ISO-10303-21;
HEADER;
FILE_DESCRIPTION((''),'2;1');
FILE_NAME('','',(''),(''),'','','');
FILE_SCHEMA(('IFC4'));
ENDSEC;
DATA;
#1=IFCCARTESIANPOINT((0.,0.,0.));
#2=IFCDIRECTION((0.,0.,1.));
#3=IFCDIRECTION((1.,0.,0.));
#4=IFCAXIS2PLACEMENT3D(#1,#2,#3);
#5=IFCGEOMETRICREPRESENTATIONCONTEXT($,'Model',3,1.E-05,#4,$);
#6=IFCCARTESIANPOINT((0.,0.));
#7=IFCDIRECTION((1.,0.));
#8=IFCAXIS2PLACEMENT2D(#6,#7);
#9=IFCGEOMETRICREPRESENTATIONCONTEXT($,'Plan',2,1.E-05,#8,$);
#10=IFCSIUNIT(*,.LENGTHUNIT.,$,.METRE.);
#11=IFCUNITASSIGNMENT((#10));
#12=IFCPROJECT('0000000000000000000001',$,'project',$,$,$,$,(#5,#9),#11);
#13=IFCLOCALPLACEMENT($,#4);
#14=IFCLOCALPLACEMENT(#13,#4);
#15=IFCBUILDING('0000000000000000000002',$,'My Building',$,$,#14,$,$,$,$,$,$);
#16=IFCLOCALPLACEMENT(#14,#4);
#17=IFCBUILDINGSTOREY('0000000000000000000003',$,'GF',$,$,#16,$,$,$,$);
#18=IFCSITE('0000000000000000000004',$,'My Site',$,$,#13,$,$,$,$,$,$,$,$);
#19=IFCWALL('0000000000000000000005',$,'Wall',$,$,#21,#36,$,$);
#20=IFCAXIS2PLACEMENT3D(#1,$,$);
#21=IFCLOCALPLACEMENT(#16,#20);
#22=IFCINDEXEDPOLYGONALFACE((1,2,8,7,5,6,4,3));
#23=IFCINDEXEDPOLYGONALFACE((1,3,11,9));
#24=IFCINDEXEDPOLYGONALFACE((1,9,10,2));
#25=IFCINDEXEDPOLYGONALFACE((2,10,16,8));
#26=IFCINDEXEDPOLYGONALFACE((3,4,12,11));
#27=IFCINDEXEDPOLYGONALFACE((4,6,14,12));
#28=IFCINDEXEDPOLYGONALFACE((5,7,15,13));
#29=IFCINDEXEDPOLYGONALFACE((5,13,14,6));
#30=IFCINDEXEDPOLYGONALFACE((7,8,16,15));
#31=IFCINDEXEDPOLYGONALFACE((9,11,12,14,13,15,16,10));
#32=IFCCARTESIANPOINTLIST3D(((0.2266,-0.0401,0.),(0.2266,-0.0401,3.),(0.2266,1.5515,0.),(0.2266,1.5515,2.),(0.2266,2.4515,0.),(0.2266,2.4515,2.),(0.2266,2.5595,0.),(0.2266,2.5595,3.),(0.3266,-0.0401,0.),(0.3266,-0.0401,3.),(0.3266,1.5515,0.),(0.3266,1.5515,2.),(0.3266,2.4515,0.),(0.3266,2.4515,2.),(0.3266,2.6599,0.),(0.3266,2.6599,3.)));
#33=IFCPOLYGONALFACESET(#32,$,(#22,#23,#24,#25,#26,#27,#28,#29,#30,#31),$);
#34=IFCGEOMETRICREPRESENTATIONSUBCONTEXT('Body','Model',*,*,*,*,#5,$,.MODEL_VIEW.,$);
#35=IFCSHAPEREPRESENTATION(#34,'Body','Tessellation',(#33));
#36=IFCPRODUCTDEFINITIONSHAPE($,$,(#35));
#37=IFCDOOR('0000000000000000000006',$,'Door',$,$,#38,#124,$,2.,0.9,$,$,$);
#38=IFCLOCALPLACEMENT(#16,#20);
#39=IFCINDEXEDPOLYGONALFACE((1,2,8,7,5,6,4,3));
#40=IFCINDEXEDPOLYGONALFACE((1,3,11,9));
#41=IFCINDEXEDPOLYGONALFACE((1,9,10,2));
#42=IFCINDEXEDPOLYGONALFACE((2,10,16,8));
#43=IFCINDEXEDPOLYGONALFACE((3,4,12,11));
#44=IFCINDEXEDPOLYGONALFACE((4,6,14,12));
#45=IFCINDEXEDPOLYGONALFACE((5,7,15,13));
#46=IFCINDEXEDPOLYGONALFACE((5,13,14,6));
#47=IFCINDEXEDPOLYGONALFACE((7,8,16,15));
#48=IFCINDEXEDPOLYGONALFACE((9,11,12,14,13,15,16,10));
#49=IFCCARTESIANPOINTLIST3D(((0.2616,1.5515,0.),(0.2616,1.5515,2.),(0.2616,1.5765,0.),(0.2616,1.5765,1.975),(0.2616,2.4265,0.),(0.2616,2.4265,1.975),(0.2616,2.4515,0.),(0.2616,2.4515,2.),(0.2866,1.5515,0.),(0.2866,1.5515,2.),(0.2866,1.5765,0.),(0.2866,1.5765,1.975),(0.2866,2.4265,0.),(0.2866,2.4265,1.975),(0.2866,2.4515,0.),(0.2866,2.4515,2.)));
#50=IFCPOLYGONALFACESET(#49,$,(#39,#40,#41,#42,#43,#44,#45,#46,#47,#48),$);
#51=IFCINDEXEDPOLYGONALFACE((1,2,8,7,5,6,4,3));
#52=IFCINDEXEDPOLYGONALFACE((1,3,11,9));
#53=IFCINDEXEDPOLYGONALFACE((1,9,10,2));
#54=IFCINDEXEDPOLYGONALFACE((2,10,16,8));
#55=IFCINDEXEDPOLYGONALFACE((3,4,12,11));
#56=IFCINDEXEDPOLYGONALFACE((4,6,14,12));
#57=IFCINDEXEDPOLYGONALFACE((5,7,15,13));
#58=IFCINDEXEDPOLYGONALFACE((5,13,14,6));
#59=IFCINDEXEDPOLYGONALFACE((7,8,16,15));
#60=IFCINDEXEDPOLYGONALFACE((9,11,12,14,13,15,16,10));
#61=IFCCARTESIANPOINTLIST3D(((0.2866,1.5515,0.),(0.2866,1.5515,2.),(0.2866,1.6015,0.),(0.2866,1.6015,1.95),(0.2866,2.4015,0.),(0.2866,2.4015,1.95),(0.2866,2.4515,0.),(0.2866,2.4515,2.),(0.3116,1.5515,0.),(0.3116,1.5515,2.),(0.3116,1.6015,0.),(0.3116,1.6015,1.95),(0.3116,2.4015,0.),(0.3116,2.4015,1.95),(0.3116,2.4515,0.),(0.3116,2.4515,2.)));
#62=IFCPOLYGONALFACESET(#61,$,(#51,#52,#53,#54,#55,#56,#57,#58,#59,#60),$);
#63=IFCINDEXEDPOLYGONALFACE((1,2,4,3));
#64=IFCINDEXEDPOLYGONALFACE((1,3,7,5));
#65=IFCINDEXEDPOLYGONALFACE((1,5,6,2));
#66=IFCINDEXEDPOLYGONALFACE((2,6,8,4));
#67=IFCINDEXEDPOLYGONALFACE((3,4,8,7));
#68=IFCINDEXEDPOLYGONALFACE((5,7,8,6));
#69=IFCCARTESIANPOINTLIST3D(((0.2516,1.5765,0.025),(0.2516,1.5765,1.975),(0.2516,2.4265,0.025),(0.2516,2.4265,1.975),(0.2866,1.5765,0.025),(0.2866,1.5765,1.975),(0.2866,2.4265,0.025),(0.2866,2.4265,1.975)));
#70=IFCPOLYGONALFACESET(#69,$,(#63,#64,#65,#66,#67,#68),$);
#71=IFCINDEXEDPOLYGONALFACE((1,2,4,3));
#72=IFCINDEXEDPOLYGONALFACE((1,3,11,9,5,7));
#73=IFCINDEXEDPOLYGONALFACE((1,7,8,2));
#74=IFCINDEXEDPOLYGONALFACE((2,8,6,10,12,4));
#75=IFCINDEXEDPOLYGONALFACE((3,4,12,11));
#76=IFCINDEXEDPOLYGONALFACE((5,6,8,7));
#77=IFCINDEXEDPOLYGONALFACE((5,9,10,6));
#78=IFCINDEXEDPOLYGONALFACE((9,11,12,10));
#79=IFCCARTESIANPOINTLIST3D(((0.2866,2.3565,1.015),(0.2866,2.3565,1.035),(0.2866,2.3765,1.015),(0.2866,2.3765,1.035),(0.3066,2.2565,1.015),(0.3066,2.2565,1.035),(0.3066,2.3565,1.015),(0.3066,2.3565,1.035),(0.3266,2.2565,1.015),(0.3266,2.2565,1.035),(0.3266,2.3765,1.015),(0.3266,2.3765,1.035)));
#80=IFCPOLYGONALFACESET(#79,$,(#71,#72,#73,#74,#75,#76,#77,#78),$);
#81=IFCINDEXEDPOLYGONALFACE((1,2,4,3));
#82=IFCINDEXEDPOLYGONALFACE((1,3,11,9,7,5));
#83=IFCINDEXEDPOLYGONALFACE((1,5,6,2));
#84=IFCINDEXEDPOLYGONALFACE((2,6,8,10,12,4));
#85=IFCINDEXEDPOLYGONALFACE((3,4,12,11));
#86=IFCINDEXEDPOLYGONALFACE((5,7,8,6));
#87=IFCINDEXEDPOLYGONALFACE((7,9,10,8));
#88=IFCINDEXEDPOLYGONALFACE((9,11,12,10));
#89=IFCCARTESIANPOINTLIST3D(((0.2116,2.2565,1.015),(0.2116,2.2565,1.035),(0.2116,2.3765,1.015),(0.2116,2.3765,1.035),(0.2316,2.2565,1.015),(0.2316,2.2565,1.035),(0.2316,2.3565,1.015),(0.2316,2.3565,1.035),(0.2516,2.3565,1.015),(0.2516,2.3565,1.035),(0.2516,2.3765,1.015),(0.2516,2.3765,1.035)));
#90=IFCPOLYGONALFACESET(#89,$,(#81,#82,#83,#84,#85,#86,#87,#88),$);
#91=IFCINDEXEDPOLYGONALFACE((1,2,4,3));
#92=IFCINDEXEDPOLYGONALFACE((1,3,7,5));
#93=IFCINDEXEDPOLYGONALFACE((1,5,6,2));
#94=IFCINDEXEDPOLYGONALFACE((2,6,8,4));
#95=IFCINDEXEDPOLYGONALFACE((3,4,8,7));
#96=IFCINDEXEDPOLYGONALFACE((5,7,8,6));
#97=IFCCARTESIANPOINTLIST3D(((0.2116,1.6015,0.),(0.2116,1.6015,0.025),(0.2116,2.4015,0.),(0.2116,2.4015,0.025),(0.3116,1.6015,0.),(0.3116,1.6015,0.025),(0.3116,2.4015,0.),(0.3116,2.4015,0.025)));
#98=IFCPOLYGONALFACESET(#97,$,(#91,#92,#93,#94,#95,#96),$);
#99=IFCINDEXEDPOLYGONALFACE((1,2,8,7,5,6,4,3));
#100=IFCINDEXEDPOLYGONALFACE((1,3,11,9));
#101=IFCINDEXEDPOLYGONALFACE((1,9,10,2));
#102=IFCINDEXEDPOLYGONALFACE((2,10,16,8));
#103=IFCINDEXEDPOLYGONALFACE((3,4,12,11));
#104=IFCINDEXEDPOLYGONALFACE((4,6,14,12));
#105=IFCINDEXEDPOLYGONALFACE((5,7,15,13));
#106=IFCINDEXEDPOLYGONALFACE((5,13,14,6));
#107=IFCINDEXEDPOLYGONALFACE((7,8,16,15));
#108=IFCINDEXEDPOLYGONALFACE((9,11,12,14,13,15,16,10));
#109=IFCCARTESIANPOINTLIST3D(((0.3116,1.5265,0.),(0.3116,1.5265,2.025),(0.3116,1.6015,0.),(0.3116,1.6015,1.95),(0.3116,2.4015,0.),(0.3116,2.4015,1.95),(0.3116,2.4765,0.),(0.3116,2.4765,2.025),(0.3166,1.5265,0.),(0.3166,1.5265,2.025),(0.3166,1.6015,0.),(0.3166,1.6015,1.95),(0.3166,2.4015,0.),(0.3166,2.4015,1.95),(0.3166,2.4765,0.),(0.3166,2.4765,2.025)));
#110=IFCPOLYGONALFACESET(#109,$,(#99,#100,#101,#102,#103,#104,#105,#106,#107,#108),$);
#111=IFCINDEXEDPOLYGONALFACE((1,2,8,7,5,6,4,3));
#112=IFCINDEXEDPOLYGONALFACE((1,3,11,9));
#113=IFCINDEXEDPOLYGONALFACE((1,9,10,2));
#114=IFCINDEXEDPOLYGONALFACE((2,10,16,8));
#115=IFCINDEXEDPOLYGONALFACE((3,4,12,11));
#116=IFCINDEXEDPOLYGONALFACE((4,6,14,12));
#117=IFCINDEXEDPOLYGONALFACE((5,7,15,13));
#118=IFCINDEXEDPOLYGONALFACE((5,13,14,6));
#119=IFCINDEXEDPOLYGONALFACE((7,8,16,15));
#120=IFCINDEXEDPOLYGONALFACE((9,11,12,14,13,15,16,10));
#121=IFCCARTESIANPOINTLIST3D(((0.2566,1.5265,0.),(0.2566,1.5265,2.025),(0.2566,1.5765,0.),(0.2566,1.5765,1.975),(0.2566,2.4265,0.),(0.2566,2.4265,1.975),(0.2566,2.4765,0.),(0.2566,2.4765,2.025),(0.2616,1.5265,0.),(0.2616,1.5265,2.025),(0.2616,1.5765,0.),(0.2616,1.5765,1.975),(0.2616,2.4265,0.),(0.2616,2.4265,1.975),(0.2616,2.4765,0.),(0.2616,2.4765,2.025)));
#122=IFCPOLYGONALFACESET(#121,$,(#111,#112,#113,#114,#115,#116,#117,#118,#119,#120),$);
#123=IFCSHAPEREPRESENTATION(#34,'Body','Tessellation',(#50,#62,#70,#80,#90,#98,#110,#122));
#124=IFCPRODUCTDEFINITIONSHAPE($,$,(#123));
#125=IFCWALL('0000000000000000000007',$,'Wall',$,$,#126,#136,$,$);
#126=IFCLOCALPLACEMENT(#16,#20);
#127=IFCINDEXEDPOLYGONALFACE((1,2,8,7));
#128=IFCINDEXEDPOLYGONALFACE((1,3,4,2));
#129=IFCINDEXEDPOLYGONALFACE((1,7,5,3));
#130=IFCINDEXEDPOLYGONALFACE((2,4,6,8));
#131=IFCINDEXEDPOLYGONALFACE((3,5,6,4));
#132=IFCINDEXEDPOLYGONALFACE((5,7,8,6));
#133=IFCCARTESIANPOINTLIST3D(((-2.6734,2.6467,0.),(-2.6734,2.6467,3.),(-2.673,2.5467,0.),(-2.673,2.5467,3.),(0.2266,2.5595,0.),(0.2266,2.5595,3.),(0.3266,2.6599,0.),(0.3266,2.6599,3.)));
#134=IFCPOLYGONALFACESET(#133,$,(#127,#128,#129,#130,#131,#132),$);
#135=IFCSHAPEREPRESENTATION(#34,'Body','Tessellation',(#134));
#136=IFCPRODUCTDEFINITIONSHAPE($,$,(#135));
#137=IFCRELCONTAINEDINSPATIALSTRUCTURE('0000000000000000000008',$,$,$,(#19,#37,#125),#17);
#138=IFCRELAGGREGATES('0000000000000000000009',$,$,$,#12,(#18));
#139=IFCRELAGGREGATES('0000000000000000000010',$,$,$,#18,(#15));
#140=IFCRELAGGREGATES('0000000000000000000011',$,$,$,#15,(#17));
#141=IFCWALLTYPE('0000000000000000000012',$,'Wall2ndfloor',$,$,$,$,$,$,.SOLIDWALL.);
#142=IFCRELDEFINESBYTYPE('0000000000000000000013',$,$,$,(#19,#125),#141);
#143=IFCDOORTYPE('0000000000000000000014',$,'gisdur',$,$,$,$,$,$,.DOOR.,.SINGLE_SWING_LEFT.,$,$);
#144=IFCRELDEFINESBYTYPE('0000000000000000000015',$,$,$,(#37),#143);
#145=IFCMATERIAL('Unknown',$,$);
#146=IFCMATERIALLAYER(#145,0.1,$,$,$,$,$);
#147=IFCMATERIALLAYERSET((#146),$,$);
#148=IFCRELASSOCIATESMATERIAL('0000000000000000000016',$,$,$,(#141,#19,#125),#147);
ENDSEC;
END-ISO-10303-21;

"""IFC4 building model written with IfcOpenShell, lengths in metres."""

from ifc_helpers import new_model, entity, si_unit, frame, origin_with_axes, origin_2d_with_axis, place, context, subcontext, project, spatial, line, indexed_curve, outline, extrude, shape, source, transform, mapped, material, layer, layer_set, layer_usage, type_object, type_shapes, element, fill, save


model = new_model("IFC4")

# Units and contexts
model_context = context("Model", 3, precision=1e-05, world=origin_with_axes())
plan_context = context("Plan", 2, precision=1e-05, world=origin_2d_with_axis())
body_context_1 = subcontext(model_context, "Body", "Model", "MODEL_VIEW")
body_context_2 = subcontext(plan_context, "Body", "Plan", "PLAN_VIEW")
ifc_project = project(units=[si_unit("LENGTHUNIT", "METRE")], contexts=[model_context, plan_context])

# Site, building, storey
site_placement = place(None, origin_with_axes())
site = spatial("IfcSite", under=ifc_project, at=site_placement, Name="My Site")
building_placement = place(site_placement, origin_with_axes())
building = spatial("IfcBuilding", under=site, at=building_placement, Name="My Building")
storey_placement = place(building_placement, origin_with_axes())
storey = spatial("IfcBuildingStorey", under=building, at=storey_placement, Name="GF")

# Shared definitions
ifc_material = material(Name="Unknown")

# Shared definitions
ifc_layer_1 = layer(ifc_material, 0.1)
ifc_layer_set_1 = layer_set([ifc_layer_1])
wall_type_1 = type_object("IfcWallType", Name="Wall2ndfloor", PredefinedType="SOLIDWALL", material=ifc_layer_set_1)

# Wall, opening, door
ifc_layer_usage_1 = layer_usage(ifc_layer_set_1, "AXIS2", "POSITIVE", 0.0)
wall_1_placement = place(storey_placement, frame((0.3266, -0.0401, 0.0), z_axis=(0.0, 0.0, 1.0), x_axis=(0.0, 1.0, 0.0)))
wall_1 = element("IfcWall", 1, at=wall_1_placement, inside=storey, type_object=wall_type_1, material=ifc_layer_usage_1, Name="Wall", context=body_context_1, shape_type="SweptSolid", body=[
    extrude(outline(indexed_curve([(0.0, 0.0), (0.0, 0.1), (2.5996, 0.1), (2.7, 0.0)], segments=[line(1, 2, 3, 4, 1)])), origin_with_axes(), (0.0, 0.0, 1.0), 3.0),
])
shared_shape_1 = source(origin_with_axes(), body_context_1, "Body", "SweptSolid", [
    extrude(outline(indexed_curve([(0.0, 0.0), (0.9, 0.0), (0.9, 2.0), (0.0, 2.0)], segments=[line(1, 2, 3, 4, 1)])), frame((0.0, -0.6, 0.0), z_axis=(0.0, -1.0, 0.0), x_axis=(1.0, 0.0, 0.0)), (0.0, 0.0, -1.0), 1.2),
])
opening_1_placement = place(wall_1_placement, frame((1.5916, 0.015, 0.0), z_axis=(0.0, 0.0, 1.0), x_axis=(1.0, 0.0, 0.0)))
opening_1 = element("IfcOpeningElement", 2, at=opening_1_placement, cuts=wall_1, PredefinedType="OPENING", context=body_context_1, shape_type="MappedRepresentation", body=[
    mapped(shared_shape_1, transform((0.0, 0.0, 0.0), x_axis=(1.0, 0.0, 0.0), y_axis=(0.0, 1.0, 0.0), z_axis=(0.0, 0.0, 1.0), scale=1.0)),
])
door_type_1 = type_object("IfcDoorType", Name="gisdur", OperationType="SINGLE_SWING_LEFT", PredefinedType="DOOR")
shared_shape_2 = source(origin_with_axes(), body_context_1, "Body", "SweptSolid", [
    extrude(outline(indexed_curve([(0.0, 0.0), (0.0, 2.0), (0.9, 2.0), (0.9, 0.0), (0.875, 0.0), (0.875, 1.975), (0.025, 1.975), (0.025, 0.0)], segments=[line(1, 2, 3, 4, 5, 6, 7, 8, 1)])), frame((0.0, 0.025, 0.0), z_axis=(0.0, -1.0, 0.0), x_axis=(1.0, 0.0, 0.0)), (0.0, 0.0, -1.0), 0.025),
    extrude(outline(indexed_curve([(0.0, 0.0), (0.0, 2.0), (0.9, 2.0), (0.9, 0.0), (0.85, 0.0), (0.85, 1.95), (0.05, 1.95), (0.05, 0.0)], segments=[line(1, 2, 3, 4, 5, 6, 7, 8, 1)])), frame((0.0, 0.0, 0.0), z_axis=(0.0, -1.0, 0.0), x_axis=(1.0, 0.0, 0.0)), (0.0, 0.0, -1.0), 0.025),
    extrude(outline(indexed_curve([(0.0, 0.0), (0.85, 0.0), (0.85, 0.035), (0.0, 0.035)], segments=[line(1, 2, 3, 4, 1)])), frame((0.025, 0.025, 0.025), z_axis=(0.0, 0.0, 1.0), x_axis=(1.0, 0.0, 0.0)), (0.0, 0.0, 1.0), 1.95),
    extrude(outline(indexed_curve([(0.0, 0.0), (0.0, -0.04), (-0.12, -0.04), (-0.12, -0.02), (-0.02, -0.02), (-0.02, 0.0)], segments=[line(1, 2, 3, 4, 5, 6, 1)])), frame((0.825, 0.025, 1.015), z_axis=(0.0, 0.0, 1.0), x_axis=(1.0, 0.0, 0.0)), (0.0, 0.0, 1.0), 0.02),
    extrude(outline(indexed_curve([(0.0, 0.0), (0.0, 0.04), (-0.12, 0.04), (-0.12, 0.02), (-0.02, 0.02), (-0.02, 0.0)], segments=[line(1, 2, 3, 4, 5, 6, 1)])), frame((0.825, 0.06, 1.015), z_axis=(0.0, 0.0, 1.0), x_axis=(1.0, 0.0, 0.0)), (0.0, 0.0, 1.0), 0.02),
    extrude(outline(indexed_curve([(0.0, 0.0), (0.8, 0.0), (0.8, 0.1), (0.0, 0.1)], segments=[line(1, 2, 3, 4, 1)])), frame((0.05, 0.0, 0.0), z_axis=(0.0, 0.0, 1.0), x_axis=(1.0, 0.0, 0.0)), (0.0, 0.0, 1.0), 0.025),
    extrude(outline(indexed_curve([(0.0, 0.0), (0.0, 2.025), (0.95, 2.025), (0.95, 0.0), (0.875, 0.0), (0.875, 1.95), (0.075, 1.95), (0.075, 0.0)], segments=[line(1, 2, 3, 4, 5, 6, 7, 8, 1)])), frame((-0.025, -0.005, 0.0), z_axis=(0.0, -1.0, 0.0), x_axis=(1.0, 0.0, 0.0)), (0.0, 0.0, -1.0), 0.005),
    extrude(outline(indexed_curve([(0.0, 0.0), (0.0, 2.025), (0.95, 2.025), (0.95, 0.0), (0.9, 0.0), (0.9, 1.975), (0.05, 1.975), (0.05, 0.0)], segments=[line(1, 2, 3, 4, 5, 6, 7, 8, 1)])), frame((-0.025, 0.05, 0.0), z_axis=(0.0, -1.0, 0.0), x_axis=(1.0, 0.0, 0.0)), (0.0, 0.0, -1.0), 0.005),
])
shared_shape_3 = source(origin_with_axes(), body_context_2, "Body", "Curve2D", [
    entity("IfcIndexedPolyCurve", entity("IfcCartesianPointList2D", [[0.0, 0.0], [0.0, 0.05], [0.025, 0.05], [0.025, 0.025], [0.05, 0.025], [0.05, 0.0]]), [entity("IfcLineIndex", [1, 2, 3, 4, 5, 6, 1])]),
    entity("IfcIndexedPolyCurve", entity("IfcCartesianPointList2D", [[0.9, 0.0], [0.9, 0.05], [0.875, 0.05], [0.875, 0.025], [0.85, 0.025], [0.85, 0.0]]), [entity("IfcLineIndex", [1, 2, 3, 4, 5, 6, 1])]),
    entity("IfcTrimmedCurve", entity("IfcEllipse", entity("IfcAxis2Placement2D", entity("IfcCartesianPoint", [0.06, 0.05]), entity("IfcDirection", [1.0, 0.0])), 0.815, 0.85), [entity("IfcCartesianPoint", [0.875, 0.05])], [entity("IfcCartesianPoint", [0.06, 0.9])], True, "CARTESIAN"),
    entity("IfcIndexedPolyCurve", entity("IfcCartesianPointList2D", [[0.025, 0.05], [0.06, 0.05], [0.06, 0.9], [0.025, 0.9]]), [entity("IfcLineIndex", [1, 2, 3, 4, 1])]),
])
type_shapes(door_type_1, [shared_shape_2, shared_shape_3])
door_1_placement = place(opening_1_placement, frame((0.0, 0.0, 0.0), z_axis=(0.0, 0.0, 1.0), x_axis=(1.0, 0.0, 0.0)))
door_1 = element("IfcDoor", 3, at=door_1_placement, inside=storey, type_object=door_type_1, Name="Door", OverallHeight=2.0, OverallWidth=0.9, shapes=[
    shape(body_context_1, "Body", "MappedRepresentation", [mapped(shared_shape_2, transform((0.0, 0.0, 0.0), x_axis=(1.0, 0.0, 0.0), y_axis=(0.0, 1.0, 0.0), z_axis=(0.0, 0.0, 1.0), scale=1.0))]),
    shape(body_context_2, "Body", "MappedRepresentation", [mapped(shared_shape_3, transform((0.0, 0.0, 0.0), x_axis=(1.0, 0.0, 0.0), y_axis=(0.0, 1.0, 0.0), z_axis=(0.0, 0.0, 1.0), scale=1.0))]),
])
fill(opening_1, door_1)

# Wall
ifc_layer_usage_2 = layer_usage(ifc_layer_set_1, "AXIS2", "POSITIVE", 0.0)
wall_2_placement = place(storey_placement, frame((0.3266, 2.6599, 0.0), z_axis=(0.0, 0.0, 1.0), x_axis=(-0.99999, -0.004387, 0.0)))
element("IfcWall", 4, at=wall_2_placement, inside=storey, type_object=wall_type_1, material=ifc_layer_usage_2, Name="Wall", context=body_context_1, shape_type="SweptSolid", body=[
    extrude(outline(indexed_curve([(0.0, 0.0), (0.1004, 0.1), (3.0, 0.1), (3.0, 0.0)], segments=[line(1, 2, 3, 4, 1)])), origin_with_axes(), (0.0, 0.0, 1.0), 3.0),
])

save(model, "model.ifc")
